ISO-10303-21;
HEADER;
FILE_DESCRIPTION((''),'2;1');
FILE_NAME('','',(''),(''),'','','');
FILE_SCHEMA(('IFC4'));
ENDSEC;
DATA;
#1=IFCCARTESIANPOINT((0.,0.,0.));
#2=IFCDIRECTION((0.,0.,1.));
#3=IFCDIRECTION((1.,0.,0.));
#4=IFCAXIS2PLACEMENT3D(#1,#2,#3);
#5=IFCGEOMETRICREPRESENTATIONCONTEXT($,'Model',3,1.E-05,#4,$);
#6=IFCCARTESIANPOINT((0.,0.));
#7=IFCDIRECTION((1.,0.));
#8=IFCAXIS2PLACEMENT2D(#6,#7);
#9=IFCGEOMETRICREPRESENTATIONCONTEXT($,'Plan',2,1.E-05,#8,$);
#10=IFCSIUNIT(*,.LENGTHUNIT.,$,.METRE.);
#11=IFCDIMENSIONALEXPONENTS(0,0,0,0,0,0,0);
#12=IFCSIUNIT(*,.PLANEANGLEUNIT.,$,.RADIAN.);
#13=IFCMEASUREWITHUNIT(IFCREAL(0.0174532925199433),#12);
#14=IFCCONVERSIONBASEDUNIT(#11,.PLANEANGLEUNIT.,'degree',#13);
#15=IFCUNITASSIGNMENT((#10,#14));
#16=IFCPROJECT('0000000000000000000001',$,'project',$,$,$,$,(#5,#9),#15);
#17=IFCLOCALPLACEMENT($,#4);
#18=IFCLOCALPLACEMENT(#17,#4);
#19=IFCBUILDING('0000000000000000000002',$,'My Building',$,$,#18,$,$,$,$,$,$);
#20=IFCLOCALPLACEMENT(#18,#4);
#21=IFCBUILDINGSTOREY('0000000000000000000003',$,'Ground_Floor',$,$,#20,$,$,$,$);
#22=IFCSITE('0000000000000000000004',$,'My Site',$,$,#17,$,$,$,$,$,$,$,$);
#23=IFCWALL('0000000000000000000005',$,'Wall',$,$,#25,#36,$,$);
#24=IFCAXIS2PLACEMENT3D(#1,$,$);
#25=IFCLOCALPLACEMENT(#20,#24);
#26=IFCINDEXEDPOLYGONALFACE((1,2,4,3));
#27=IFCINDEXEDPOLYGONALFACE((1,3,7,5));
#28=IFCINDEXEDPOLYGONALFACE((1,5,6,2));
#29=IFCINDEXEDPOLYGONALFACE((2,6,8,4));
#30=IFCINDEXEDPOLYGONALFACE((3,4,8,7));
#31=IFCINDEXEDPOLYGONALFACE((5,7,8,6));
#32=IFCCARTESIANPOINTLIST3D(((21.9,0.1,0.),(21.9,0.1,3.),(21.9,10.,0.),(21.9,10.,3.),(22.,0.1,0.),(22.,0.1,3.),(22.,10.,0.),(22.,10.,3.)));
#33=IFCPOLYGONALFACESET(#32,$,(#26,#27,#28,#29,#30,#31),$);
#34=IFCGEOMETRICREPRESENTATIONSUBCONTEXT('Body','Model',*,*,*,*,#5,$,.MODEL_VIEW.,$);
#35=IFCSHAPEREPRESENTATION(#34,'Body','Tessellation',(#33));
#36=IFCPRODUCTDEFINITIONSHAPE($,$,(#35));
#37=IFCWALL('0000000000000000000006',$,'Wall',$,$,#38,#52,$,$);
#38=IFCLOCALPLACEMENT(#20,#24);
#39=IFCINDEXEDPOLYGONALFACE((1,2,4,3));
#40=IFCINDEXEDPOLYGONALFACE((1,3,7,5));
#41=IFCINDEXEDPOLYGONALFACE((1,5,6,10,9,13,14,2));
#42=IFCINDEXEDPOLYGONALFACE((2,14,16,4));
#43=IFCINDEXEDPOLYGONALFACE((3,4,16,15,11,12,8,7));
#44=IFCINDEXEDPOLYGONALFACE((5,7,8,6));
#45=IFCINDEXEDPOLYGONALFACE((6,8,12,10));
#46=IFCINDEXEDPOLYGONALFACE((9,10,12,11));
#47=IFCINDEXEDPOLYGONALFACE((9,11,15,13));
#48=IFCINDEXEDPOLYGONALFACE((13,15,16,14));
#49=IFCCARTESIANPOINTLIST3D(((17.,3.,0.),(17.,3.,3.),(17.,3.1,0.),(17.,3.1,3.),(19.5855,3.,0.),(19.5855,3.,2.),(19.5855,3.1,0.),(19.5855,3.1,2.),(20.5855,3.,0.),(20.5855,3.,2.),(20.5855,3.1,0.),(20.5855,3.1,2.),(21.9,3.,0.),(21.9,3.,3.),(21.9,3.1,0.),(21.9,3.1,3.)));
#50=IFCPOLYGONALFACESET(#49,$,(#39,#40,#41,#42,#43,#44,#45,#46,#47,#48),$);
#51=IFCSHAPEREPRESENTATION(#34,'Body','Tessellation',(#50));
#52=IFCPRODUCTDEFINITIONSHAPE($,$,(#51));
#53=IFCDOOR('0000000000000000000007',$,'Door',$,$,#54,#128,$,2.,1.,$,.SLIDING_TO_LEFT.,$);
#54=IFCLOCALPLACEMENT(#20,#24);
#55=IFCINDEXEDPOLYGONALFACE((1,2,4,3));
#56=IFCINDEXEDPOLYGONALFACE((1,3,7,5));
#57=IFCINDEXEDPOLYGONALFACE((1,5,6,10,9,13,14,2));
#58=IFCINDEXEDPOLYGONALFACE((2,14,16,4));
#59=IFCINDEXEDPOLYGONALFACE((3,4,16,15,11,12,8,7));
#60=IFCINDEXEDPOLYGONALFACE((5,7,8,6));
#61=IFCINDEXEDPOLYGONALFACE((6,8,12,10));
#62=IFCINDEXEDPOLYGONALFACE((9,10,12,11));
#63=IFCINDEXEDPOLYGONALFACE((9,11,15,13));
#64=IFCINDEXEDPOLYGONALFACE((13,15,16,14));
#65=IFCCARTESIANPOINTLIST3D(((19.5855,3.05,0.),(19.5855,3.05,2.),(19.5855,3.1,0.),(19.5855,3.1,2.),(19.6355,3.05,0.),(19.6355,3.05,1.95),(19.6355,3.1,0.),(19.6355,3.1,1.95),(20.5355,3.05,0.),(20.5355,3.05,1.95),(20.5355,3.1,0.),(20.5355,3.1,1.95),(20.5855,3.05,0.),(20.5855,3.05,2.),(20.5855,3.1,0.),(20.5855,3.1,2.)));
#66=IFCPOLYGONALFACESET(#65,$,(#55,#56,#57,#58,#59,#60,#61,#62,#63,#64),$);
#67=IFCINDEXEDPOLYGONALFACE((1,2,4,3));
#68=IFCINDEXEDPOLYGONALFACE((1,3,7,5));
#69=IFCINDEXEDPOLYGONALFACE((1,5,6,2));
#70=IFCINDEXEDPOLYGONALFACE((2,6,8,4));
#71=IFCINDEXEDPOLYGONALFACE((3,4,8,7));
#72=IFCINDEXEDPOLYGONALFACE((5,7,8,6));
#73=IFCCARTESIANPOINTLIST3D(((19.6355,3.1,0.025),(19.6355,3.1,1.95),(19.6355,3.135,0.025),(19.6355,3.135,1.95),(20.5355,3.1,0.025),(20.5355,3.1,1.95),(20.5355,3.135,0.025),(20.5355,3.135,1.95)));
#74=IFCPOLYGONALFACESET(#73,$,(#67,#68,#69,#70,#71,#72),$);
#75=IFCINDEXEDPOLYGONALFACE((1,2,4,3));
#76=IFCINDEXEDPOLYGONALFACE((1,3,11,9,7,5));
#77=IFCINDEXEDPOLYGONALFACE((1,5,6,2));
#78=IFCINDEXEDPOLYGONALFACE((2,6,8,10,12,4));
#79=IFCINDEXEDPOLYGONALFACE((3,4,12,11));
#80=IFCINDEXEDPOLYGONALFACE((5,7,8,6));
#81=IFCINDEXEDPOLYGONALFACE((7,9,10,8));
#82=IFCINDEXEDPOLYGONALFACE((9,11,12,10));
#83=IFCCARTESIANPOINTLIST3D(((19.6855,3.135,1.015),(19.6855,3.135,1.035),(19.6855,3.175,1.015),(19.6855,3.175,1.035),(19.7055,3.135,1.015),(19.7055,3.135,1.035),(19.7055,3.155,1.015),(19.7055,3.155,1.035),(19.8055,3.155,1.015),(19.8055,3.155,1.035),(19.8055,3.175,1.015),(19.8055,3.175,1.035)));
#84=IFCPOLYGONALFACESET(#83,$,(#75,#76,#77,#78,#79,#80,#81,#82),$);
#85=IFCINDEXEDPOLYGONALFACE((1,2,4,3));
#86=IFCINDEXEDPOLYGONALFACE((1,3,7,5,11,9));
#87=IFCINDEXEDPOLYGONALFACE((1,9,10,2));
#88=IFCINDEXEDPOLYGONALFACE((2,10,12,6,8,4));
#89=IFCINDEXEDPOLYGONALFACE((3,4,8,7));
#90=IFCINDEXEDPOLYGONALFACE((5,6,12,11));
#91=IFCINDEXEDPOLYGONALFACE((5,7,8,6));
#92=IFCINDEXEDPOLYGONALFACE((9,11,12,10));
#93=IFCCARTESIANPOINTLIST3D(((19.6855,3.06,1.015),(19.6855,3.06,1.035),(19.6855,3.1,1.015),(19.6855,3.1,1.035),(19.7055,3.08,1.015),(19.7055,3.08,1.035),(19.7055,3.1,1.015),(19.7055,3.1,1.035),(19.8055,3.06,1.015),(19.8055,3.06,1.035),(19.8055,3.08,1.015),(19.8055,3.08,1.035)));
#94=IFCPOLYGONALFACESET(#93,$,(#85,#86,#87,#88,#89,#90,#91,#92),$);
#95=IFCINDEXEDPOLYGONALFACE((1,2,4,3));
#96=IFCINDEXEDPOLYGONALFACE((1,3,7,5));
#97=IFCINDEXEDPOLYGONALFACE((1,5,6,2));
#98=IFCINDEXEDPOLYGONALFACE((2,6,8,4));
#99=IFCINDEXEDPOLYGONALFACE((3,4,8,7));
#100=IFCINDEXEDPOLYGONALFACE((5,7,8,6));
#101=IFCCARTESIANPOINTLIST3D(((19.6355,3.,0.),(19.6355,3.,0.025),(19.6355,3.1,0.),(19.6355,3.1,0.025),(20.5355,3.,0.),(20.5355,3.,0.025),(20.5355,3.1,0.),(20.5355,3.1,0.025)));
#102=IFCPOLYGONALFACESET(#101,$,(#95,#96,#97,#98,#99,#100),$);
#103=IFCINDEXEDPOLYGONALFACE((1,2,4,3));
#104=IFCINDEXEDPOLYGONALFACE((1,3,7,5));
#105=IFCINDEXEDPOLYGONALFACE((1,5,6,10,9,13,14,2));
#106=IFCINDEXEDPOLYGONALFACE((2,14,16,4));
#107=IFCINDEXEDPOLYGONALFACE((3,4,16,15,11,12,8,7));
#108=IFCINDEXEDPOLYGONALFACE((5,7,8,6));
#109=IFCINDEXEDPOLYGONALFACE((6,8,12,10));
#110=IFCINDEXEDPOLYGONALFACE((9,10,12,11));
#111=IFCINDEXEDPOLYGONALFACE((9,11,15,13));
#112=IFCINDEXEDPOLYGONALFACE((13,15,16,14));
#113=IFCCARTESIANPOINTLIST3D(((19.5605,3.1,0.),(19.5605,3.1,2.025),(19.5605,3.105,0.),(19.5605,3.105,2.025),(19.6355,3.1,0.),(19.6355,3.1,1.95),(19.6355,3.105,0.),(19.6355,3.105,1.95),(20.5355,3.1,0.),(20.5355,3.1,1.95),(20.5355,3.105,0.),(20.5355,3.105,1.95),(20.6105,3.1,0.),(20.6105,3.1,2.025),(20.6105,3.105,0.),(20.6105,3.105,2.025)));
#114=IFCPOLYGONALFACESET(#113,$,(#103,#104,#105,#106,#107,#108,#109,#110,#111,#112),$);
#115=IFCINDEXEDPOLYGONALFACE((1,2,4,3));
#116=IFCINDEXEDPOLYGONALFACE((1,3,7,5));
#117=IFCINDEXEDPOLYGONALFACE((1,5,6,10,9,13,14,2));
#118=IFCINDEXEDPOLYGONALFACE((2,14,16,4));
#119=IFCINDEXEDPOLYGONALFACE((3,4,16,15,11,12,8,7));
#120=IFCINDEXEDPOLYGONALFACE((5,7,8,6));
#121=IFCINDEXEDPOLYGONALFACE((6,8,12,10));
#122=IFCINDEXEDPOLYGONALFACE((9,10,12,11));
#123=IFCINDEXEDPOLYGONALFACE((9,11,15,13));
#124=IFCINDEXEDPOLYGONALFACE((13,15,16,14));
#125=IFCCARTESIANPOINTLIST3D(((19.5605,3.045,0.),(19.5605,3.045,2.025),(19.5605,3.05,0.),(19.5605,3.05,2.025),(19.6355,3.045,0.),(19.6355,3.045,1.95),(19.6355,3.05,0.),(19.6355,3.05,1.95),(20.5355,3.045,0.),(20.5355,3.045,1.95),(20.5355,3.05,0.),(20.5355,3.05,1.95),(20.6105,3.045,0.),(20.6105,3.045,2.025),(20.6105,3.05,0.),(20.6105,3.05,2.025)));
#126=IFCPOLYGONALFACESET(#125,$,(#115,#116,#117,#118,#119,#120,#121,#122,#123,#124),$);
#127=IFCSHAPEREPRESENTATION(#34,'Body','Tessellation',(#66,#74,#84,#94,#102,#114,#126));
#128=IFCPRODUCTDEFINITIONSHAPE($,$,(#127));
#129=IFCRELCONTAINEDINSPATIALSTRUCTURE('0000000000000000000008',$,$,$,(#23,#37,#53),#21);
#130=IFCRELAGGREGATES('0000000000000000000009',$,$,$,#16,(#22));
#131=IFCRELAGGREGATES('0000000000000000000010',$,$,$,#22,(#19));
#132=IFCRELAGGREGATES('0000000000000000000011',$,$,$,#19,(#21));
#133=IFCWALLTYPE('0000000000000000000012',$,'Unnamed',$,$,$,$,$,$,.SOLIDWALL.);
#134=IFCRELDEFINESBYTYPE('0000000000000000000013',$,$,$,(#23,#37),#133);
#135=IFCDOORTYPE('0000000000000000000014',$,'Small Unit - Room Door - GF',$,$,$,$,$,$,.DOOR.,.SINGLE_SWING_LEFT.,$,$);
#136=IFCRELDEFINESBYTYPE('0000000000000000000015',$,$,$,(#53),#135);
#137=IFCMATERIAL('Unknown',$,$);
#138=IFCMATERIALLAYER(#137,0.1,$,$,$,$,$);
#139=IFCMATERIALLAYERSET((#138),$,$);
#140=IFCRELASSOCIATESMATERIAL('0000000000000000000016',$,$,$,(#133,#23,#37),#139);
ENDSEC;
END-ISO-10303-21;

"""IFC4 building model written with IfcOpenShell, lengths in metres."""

from ifc_helpers import new_model, entity, si_unit, converted_unit, frame, origin_with_axes, origin_2d_with_axis, place, context, subcontext, project, spatial, line, indexed_curve, outline, extrude, shape, source, transform, mapped, material, layer, layer_set, layer_usage, type_object, type_shapes, element, fill, save


model = new_model("IFC4")

# Units and contexts
model_context = context("Model", 3, precision=1e-05, world=origin_with_axes())
plan_context = context("Plan", 2, precision=1e-05, world=origin_2d_with_axis())
body_context_1 = subcontext(model_context, "Body", "Model", "MODEL_VIEW")
body_context_2 = subcontext(plan_context, "Body", "Plan", "PLAN_VIEW")
ifc_project = project(units=[si_unit("LENGTHUNIT", "METRE"), converted_unit("PLANEANGLEUNIT", "degree", entity("IfcReal", 0.0174532925199433), si_unit("PLANEANGLEUNIT", "RADIAN"), dimensions=[0, 0, 0, 0, 0, 0, 0])], contexts=[model_context, plan_context])

# Site, building, storey
site_placement = place(None, origin_with_axes())
site = spatial("IfcSite", under=ifc_project, at=site_placement, Name="My Site")
building_placement = place(site_placement, origin_with_axes())
building = spatial("IfcBuilding", under=site, at=building_placement, Name="My Building")
storey_placement = place(building_placement, origin_with_axes())
storey = spatial("IfcBuildingStorey", under=building, at=storey_placement, Name="Ground_Floor")

# Wall
ifc_material = material(Name="Unknown")
ifc_layer = layer(ifc_material, 0.1)
ifc_layer_set = layer_set([ifc_layer])
ifc_layer_usage_1 = layer_usage(ifc_layer_set, "AXIS2", "POSITIVE", 0.0)
wall_type = type_object("IfcWallType", Name="Unnamed", PredefinedType="SOLIDWALL", material=ifc_layer_set)
wall_1_placement = place(storey_placement, frame((22.0, 0.0, 0.0), z_axis=(0.0, 0.0, 1.0), x_axis=(0.0, 1.0, 0.0)))
element("IfcWall", 1, at=wall_1_placement, inside=storey, type_object=wall_type, material=ifc_layer_usage_1, Name="Wall", context=body_context_1, shape_type="SweptSolid", body=[
    extrude(outline(indexed_curve([(0.1, 0.0), (0.1, 0.1), (10.0, 0.1), (10.0, 0.0)], segments=[line(1, 2, 3, 4, 1)])), origin_with_axes(), (0.0, 0.0, 1.0), 3.0),
])

# Wall, opening, door
ifc_layer_usage_2 = layer_usage(ifc_layer_set, "AXIS2", "POSITIVE", 0.0)
wall_2_placement = place(storey_placement, frame((17.0, 3.0, 0.0), z_axis=(0.0, 0.0, 1.0), x_axis=(1.0, 0.0, 0.0)))
wall_2 = element("IfcWall", 2, at=wall_2_placement, inside=storey, type_object=wall_type, material=ifc_layer_usage_2, Name="Wall", context=body_context_1, shape_type="SweptSolid", body=[
    extrude(outline(indexed_curve([(0.0, 0.0), (0.0, 0.1), (4.9, 0.1), (4.9, 0.0)], segments=[line(1, 2, 3, 4, 1)])), origin_with_axes(), (0.0, 0.0, 1.0), 3.0),
])
shared_shape_1 = source(origin_with_axes(), body_context_1, "Body", "SweptSolid", [
    extrude(outline(indexed_curve([(0.0, 0.0), (1.0, 0.0), (1.0, 2.0), (0.0, 2.0)], segments=[line(1, 2, 3, 4, 1)])), frame((0.0, -0.6, 0.0), z_axis=(0.0, -1.0, 0.0), x_axis=(1.0, 0.0, 0.0)), (0.0, 0.0, -1.0), 1.2),
])
opening_1_placement = place(wall_2_placement, frame((3.5855, 0.1, 0.0), z_axis=(0.0, 0.0, 1.0), x_axis=(-1.0, 0.0, 0.0)))
opening_1 = element("IfcOpeningElement", 3, at=opening_1_placement, cuts=wall_2, PredefinedType="OPENING", context=body_context_1, shape_type="MappedRepresentation", body=[
    mapped(shared_shape_1, transform((0.0, 0.0, 0.0), x_axis=(1.0, 0.0, 0.0), y_axis=(0.0, 1.0, 0.0), z_axis=(0.0, 0.0, 1.0), scale=1.0)),
])
door_type_1 = type_object("IfcDoorType", Name="Small Unit - Room Door - GF", OperationType="SINGLE_SWING_LEFT", PredefinedType="DOOR")
shared_shape_2 = source(origin_with_axes(), body_context_1, "Body", "SweptSolid", [
    extrude(outline(indexed_curve([(0.0, 0.0), (0.0, 2.0), (1.0, 2.0), (1.0, 0.0), (0.95, 0.0), (0.95, 1.95), (0.05, 1.95), (0.05, 0.0)], segments=[line(1, 2, 3, 4, 5, 6, 7, 8, 1)])), frame((0.0, 0.0, 0.0), z_axis=(0.0, -1.0, 0.0), x_axis=(1.0, 0.0, 0.0)), (0.0, 0.0, -1.0), 0.05),
    extrude(outline(indexed_curve([(0.0, 0.0), (0.9, 0.0), (0.9, 0.035), (0.0, 0.035)], segments=[line(1, 2, 3, 4, 1)])), frame((0.05, -0.035, 0.025), z_axis=(0.0, 0.0, 1.0), x_axis=(1.0, 0.0, 0.0)), (0.0, 0.0, 1.0), 1.925),
    extrude(outline(indexed_curve([(0.0, 0.0), (0.0, -0.04), (-0.12, -0.04), (-0.12, -0.02), (-0.02, -0.02), (-0.02, 0.0)], segments=[line(1, 2, 3, 4, 5, 6, 1)])), frame((0.9, -0.035, 1.015), z_axis=(0.0, 0.0, 1.0), x_axis=(1.0, 0.0, 0.0)), (0.0, 0.0, 1.0), 0.02),
    extrude(outline(indexed_curve([(0.0, 0.0), (0.0, 0.04), (-0.12, 0.04), (-0.12, 0.02), (-0.02, 0.02), (-0.02, 0.0)], segments=[line(1, 2, 3, 4, 5, 6, 1)])), frame((0.9, 0.0, 1.015), z_axis=(0.0, 0.0, 1.0), x_axis=(1.0, 0.0, 0.0)), (0.0, 0.0, 1.0), 0.02),
    extrude(outline(indexed_curve([(0.0, 0.0), (0.9, 0.0), (0.9, 0.1), (0.0, 0.1)], segments=[line(1, 2, 3, 4, 1)])), frame((0.05, 0.0, 0.0), z_axis=(0.0, 0.0, 1.0), x_axis=(1.0, 0.0, 0.0)), (0.0, 0.0, 1.0), 0.025),
    extrude(outline(indexed_curve([(0.0, 0.0), (0.0, 2.025), (1.05, 2.025), (1.05, 0.0), (0.975, 0.0), (0.975, 1.95), (0.075, 1.95), (0.075, 0.0)], segments=[line(1, 2, 3, 4, 5, 6, 7, 8, 1)])), frame((-0.025, -0.005, 0.0), z_axis=(0.0, -1.0, 0.0), x_axis=(1.0, 0.0, 0.0)), (0.0, 0.0, -1.0), 0.005),
    extrude(outline(indexed_curve([(0.0, 0.0), (0.0, 2.025), (1.05, 2.025), (1.05, 0.0), (0.975, 0.0), (0.975, 1.95), (0.075, 1.95), (0.075, 0.0)], segments=[line(1, 2, 3, 4, 5, 6, 7, 8, 1)])), frame((-0.025, 0.05, 0.0), z_axis=(0.0, -1.0, 0.0), x_axis=(1.0, 0.0, 0.0)), (0.0, 0.0, -1.0), 0.005),
])
shared_shape_3 = source(origin_with_axes(), body_context_2, "Body", "Curve2D", [
    entity("IfcIndexedPolyCurve", entity("IfcCartesianPointList2D", [[0.0, 0.0], [0.05, 0.0], [0.05, 0.05], [0.0, 0.05]]), [entity("IfcLineIndex", [1, 2, 3, 4, 1])]),
    entity("IfcIndexedPolyCurve", entity("IfcCartesianPointList2D", [[1.0, 0.0], [0.95, 0.0], [0.95, 0.05], [1.0, 0.05]]), [entity("IfcLineIndex", [1, 2, 3, 4, 1])]),
    entity("IfcIndexedPolyCurve", entity("IfcCartesianPointList2D", [[-0.4, -0.035], [0.5, -0.035], [0.5, 0.0], [-0.4, 0.0]]), [entity("IfcLineIndex", [1, 2, 3, 4, 1])]),
])
type_shapes(door_type_1, [shared_shape_2, shared_shape_3])
door_1_placement = place(opening_1_placement, origin_with_axes())
door_1 = element("IfcDoor", 4, at=door_1_placement, inside=storey, type_object=door_type_1, Name="Door", OperationType="SLIDING_TO_LEFT", OverallHeight=2.0, OverallWidth=1.0, shapes=[
    shape(body_context_1, "Body", "MappedRepresentation", [mapped(shared_shape_2, transform((0.0, 0.0, 0.0), x_axis=(1.0, 0.0, 0.0), y_axis=(0.0, 1.0, 0.0), z_axis=(0.0, 0.0, 1.0), scale=1.0))]),
    shape(body_context_2, "Body", "MappedRepresentation", [mapped(shared_shape_3, transform((0.0, 0.0, 0.0), x_axis=(1.0, 0.0, 0.0), y_axis=(0.0, 1.0, 0.0), z_axis=(0.0, 0.0, 1.0), scale=1.0))]),
])
fill(opening_1, door_1)

save(model, "model.ifc")
